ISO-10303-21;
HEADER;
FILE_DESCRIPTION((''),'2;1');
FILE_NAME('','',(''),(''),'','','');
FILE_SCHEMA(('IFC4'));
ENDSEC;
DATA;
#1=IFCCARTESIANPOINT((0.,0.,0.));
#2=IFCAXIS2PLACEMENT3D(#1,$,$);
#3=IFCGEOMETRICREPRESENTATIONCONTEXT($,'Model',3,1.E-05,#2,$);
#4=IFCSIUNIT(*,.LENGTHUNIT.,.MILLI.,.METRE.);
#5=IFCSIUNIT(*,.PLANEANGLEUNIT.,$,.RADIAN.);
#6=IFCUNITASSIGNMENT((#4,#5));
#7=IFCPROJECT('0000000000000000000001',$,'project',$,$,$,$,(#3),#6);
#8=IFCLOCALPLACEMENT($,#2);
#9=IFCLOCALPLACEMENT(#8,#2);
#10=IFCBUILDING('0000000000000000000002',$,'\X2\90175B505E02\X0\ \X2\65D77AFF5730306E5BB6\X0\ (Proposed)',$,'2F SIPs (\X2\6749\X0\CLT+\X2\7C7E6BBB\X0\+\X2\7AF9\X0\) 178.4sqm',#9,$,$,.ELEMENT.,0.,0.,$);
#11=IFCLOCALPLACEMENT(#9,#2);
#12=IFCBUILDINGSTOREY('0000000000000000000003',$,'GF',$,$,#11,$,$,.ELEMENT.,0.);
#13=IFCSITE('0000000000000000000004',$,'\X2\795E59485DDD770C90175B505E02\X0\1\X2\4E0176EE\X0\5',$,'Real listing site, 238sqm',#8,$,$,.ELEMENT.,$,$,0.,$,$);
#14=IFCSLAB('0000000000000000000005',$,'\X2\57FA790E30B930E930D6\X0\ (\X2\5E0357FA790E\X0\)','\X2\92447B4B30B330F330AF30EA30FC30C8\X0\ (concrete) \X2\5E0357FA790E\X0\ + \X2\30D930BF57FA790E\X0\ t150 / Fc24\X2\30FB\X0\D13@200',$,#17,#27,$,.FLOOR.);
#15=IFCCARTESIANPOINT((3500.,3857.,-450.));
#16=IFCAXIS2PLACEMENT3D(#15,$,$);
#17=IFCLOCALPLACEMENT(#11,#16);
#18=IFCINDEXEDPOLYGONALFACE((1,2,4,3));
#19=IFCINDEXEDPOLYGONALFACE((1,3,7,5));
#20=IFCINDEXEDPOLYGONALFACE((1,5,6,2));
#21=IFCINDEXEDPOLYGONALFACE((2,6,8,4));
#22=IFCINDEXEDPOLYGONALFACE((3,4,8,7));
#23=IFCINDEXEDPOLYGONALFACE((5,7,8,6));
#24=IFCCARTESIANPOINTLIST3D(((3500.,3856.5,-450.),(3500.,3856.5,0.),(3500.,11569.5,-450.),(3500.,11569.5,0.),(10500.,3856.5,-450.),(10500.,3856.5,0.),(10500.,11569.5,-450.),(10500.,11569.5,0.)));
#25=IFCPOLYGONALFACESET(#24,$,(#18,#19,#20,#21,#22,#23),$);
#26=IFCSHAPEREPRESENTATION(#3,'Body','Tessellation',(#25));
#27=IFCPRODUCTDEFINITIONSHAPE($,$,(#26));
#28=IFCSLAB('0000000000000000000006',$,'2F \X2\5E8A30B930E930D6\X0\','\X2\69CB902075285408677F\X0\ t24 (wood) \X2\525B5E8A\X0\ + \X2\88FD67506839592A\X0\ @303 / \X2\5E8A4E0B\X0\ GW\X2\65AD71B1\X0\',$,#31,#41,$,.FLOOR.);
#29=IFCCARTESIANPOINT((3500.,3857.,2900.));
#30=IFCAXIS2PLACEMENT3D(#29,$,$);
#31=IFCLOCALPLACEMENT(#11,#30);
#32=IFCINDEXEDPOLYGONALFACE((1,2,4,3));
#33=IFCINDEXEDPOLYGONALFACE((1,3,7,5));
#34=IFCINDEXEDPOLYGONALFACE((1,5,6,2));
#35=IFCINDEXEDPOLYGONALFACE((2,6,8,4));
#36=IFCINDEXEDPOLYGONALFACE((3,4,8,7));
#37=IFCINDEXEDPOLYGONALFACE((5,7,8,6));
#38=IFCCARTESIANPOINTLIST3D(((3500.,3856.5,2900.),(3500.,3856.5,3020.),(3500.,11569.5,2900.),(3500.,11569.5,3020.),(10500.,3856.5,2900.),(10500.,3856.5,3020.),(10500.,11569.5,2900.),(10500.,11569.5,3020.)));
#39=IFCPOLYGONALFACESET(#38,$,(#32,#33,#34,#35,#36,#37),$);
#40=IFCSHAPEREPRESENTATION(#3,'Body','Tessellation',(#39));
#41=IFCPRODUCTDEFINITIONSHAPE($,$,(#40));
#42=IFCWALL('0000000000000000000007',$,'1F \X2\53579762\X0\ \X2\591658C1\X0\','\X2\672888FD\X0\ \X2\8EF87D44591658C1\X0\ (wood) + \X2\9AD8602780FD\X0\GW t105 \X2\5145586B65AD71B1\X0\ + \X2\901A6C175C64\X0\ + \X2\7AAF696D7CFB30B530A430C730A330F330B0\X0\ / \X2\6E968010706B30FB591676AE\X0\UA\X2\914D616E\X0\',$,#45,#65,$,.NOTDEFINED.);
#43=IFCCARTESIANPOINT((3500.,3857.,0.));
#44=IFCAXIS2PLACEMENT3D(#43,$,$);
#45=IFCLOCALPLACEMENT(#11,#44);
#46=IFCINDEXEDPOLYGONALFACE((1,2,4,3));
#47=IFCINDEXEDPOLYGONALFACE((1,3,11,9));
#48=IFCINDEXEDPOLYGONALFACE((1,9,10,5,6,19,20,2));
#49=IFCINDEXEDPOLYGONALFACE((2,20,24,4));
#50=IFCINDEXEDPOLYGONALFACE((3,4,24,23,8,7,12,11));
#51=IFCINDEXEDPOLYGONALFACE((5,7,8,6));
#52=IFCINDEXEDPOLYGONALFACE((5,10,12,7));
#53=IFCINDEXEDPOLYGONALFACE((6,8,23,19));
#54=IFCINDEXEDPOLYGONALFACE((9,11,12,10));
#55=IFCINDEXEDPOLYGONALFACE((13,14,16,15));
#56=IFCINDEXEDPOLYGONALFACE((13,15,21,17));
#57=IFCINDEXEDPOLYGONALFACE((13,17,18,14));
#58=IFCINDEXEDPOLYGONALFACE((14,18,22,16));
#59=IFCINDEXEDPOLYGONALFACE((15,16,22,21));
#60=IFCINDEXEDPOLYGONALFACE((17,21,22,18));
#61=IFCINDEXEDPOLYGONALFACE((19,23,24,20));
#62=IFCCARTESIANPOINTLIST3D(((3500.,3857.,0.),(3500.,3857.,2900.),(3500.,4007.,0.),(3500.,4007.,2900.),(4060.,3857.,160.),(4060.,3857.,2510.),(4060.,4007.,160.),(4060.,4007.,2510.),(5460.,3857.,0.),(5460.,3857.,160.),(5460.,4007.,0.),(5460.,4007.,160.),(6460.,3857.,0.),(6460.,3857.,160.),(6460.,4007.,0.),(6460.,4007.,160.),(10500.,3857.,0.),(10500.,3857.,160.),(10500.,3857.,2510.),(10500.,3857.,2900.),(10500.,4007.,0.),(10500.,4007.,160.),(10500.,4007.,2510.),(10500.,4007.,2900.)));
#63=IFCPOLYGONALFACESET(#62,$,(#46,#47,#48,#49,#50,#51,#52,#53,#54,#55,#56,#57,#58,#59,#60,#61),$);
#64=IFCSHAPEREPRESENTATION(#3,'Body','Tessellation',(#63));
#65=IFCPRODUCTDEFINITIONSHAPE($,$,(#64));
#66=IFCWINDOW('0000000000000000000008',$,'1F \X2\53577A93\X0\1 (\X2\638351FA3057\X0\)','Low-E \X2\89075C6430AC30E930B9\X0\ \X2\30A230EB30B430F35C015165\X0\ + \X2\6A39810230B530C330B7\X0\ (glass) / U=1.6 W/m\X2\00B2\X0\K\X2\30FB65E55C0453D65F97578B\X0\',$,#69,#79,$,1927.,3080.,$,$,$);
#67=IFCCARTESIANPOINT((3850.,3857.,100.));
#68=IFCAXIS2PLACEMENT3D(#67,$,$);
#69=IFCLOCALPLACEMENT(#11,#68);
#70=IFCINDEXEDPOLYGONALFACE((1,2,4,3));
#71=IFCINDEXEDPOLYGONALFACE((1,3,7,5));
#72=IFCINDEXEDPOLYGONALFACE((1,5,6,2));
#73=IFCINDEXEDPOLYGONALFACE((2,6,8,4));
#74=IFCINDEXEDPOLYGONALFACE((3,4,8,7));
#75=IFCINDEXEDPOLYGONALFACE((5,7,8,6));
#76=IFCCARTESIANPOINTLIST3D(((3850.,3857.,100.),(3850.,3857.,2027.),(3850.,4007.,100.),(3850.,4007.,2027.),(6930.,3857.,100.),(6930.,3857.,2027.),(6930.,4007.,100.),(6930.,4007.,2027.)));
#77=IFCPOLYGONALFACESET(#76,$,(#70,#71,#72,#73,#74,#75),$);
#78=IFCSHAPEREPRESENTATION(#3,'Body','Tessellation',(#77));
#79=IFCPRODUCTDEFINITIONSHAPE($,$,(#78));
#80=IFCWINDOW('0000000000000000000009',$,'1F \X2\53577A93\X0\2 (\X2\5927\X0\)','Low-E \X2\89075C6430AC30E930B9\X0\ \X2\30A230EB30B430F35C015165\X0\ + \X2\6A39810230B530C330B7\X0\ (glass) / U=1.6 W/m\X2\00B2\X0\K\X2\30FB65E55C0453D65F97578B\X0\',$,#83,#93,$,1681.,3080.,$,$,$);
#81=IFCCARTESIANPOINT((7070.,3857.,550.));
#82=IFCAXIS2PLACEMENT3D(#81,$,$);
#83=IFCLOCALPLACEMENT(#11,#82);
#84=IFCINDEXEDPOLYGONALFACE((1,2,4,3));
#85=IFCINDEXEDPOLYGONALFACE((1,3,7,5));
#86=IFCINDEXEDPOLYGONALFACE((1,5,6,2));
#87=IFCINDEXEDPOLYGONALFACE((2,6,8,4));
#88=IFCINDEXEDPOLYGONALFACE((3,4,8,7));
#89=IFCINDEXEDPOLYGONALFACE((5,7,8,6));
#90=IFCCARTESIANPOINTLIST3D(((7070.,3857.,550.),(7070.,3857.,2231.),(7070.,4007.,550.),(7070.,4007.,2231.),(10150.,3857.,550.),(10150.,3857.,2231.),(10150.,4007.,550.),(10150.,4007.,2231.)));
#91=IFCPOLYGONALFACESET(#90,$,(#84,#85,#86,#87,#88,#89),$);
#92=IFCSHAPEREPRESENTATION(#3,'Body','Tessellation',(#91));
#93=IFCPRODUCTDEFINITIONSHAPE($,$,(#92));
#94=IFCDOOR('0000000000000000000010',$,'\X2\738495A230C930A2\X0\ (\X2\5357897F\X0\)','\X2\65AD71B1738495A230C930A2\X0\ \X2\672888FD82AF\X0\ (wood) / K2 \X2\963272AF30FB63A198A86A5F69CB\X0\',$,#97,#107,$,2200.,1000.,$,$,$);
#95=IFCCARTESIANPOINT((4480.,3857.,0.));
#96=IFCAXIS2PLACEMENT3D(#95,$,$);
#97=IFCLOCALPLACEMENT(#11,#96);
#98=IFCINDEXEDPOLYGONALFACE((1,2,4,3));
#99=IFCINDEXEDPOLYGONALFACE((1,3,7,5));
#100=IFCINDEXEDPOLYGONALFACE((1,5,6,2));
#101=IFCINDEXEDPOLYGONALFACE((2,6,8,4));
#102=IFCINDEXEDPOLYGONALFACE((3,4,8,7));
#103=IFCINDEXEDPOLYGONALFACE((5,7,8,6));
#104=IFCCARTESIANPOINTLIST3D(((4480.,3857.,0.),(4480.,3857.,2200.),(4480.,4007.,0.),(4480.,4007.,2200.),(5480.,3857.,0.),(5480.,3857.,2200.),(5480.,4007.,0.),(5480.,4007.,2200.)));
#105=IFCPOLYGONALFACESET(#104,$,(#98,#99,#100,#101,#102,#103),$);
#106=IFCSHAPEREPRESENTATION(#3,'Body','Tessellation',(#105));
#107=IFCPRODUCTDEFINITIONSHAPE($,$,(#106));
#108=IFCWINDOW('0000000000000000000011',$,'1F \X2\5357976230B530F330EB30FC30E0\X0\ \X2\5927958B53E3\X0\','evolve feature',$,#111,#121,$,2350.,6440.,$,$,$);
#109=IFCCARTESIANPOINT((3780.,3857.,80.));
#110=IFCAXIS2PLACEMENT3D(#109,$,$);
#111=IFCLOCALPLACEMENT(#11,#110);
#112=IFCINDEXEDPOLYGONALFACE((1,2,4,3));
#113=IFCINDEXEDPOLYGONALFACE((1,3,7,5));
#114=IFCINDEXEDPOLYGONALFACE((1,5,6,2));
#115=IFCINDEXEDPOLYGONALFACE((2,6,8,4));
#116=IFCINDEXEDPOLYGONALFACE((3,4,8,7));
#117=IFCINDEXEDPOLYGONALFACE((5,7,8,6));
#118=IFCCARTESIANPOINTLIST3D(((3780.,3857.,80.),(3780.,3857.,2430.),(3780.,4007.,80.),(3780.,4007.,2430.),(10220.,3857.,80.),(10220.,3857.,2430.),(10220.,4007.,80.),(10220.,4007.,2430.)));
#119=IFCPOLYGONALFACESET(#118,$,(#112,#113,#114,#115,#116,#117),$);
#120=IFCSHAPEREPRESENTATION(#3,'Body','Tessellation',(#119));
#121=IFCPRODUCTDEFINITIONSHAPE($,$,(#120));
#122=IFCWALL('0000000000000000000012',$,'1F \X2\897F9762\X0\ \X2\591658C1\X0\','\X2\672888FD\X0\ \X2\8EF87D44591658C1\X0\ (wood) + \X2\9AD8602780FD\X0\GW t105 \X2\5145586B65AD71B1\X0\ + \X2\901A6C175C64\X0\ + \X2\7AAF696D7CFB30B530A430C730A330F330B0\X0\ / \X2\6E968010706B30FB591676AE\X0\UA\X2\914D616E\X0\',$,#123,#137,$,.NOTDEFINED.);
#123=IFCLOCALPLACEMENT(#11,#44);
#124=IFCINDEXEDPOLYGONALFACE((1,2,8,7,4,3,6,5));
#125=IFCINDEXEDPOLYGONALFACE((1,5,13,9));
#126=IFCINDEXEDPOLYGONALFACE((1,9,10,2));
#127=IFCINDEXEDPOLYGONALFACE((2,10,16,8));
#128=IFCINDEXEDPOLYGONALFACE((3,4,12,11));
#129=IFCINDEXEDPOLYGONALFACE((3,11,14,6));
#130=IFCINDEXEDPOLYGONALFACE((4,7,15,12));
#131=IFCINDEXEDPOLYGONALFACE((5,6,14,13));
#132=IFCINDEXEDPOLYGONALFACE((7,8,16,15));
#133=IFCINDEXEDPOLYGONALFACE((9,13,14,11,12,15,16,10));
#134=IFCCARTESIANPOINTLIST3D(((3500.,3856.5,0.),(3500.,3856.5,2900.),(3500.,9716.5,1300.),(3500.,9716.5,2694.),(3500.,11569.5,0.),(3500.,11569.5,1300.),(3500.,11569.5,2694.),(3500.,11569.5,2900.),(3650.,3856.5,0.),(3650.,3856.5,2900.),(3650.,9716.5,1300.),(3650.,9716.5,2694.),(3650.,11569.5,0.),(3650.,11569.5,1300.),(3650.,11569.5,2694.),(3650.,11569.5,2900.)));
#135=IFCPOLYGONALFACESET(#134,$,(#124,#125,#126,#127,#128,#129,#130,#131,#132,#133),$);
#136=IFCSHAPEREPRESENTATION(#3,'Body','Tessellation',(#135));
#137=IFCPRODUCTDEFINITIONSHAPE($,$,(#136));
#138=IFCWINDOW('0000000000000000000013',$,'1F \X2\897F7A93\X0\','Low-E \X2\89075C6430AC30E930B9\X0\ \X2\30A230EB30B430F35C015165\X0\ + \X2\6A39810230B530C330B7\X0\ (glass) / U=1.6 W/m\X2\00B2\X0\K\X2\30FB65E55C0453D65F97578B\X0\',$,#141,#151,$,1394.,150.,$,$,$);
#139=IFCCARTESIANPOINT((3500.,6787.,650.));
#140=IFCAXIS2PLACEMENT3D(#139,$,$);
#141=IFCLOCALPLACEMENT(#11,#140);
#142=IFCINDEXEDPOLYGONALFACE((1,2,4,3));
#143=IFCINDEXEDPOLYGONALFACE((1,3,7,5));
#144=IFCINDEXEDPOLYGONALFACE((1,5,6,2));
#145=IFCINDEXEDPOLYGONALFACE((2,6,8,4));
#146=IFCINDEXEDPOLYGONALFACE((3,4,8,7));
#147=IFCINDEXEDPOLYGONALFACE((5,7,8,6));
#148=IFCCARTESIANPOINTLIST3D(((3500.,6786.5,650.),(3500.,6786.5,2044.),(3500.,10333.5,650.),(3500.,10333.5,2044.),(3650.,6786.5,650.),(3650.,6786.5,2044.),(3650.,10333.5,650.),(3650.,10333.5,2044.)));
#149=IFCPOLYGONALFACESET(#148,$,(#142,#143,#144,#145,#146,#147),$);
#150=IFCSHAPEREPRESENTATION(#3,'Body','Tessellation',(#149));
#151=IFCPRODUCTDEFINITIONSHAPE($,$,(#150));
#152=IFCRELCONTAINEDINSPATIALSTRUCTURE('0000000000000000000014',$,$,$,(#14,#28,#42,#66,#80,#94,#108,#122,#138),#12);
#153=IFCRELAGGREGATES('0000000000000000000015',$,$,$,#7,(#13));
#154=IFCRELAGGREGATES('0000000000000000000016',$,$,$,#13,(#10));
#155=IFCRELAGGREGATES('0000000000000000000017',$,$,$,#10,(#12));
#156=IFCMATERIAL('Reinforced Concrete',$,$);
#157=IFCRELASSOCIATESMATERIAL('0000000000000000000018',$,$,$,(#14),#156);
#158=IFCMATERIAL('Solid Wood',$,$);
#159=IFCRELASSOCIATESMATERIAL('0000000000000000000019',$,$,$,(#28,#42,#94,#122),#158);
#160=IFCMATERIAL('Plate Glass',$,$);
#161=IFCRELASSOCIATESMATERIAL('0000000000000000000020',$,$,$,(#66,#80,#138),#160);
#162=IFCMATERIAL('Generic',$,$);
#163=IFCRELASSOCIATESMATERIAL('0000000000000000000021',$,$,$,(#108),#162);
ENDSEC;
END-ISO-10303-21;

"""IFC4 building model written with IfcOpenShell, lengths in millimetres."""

from ifc_helpers import new_model, si_unit, frame, frame_2d, origin, place, context, project, spatial, rectangle, extrude, material, element, fill, save


model = new_model("IFC4")

# Units and contexts
model_context = context("Model", 3, precision=1e-05, world=origin())
ifc_project = project(units=[si_unit("LENGTHUNIT", "METRE", prefix="MILLI"), si_unit("PLANEANGLEUNIT", "RADIAN")], contexts=[model_context])

# Site, building, storey
site_placement = place(None, origin())
site = spatial("IfcSite", under=ifc_project, at=site_placement, Name="神奈川県逗子市1丁目5", ObjectType="Real listing site, 238sqm", CompositionType="ELEMENT", RefElevation=0.0)
building_placement = place(site_placement, origin())
building = spatial("IfcBuilding", under=site, at=building_placement, Name="逗子市 旗竿地の家 (Proposed)", ObjectType="2F SIPs (杉CLT+籾殻+竹) 178.4sqm", CompositionType="ELEMENT", ElevationOfRefHeight=0.0, ElevationOfTerrain=0.0)
storey_placement = place(building_placement, origin())
storey = spatial("IfcBuildingStorey", under=building, at=storey_placement, Name="GF", CompositionType="ELEMENT", Elevation=0.0)

# Slabs
ifc_material_1 = material(Name="Reinforced Concrete")
slab_1_placement = place(storey_placement, frame((3500.0, 3857.0, -450.0)))
element("IfcSlab", 1, at=slab_1_placement, inside=storey, material=ifc_material_1, Name="基礎スラブ (布基礎)", Description="鉄筋コンクリート (concrete) 布基礎 + ベタ基礎 t150 / Fc24・D13@200", PredefinedType="FLOOR", context=model_context, shape_type="SweptSolid", body=[
    extrude(rectangle(XDim=7000.0, YDim=7713.0, at=frame_2d((3500.0, 3856.0))), frame((3500.0, 3857.0, -450.0)), (0.0, 0.0, 1.0), 450.0),
])
ifc_material_2 = material(Name="Solid Wood")
slab_2_placement = place(storey_placement, frame((3500.0, 3857.0, 2900.0)))
element("IfcSlab", 2, at=slab_2_placement, inside=storey, material=ifc_material_2, Name="2F 床スラブ", Description="構造用合板 t24 (wood) 剛床 + 製材根太 @303 / 床下 GW断熱", PredefinedType="FLOOR", context=model_context, shape_type="SweptSolid", body=[
    extrude(rectangle(XDim=7000.0, YDim=7713.0, at=frame_2d((3500.0, 3856.0))), frame((3500.0, 3857.0, 2900.0)), (0.0, 0.0, 1.0), 120.0),
])
ifc_material_3 = material(Name="Generic")

# Wall, openings, windows, door
wall_1_placement = place(storey_placement, frame((3500.0, 3857.0, 0.0)))
wall_1 = element("IfcWall", 3, at=wall_1_placement, inside=storey, material=ifc_material_2, Name="1F 南面 外壁", Description="木製 軸組外壁 (wood) + 高性能GW t105 充填断熱 + 通気層 + 窯業系サイディング / 準耐火・外皮UA配慮", PredefinedType="NOTDEFINED", context=model_context, shape_type="SweptSolid", body=[
    extrude(rectangle(XDim=7000.0, YDim=150.0, at=frame_2d((3500.0, 75.0))), frame((3500.0, 3857.0, 0.0)), (0.0, 0.0, 1.0), 2900.0),
])
opening_1_placement = place(storey_placement, frame((3850.0, 3857.0, 100.0)))
opening_1 = element("IfcOpeningElement", 4, at=opening_1_placement, cuts=wall_1, PredefinedType="NOTDEFINED", context=model_context, shape_type="SweptSolid", body=[
    extrude(rectangle(XDim=3080.0, YDim=150.0, at=frame_2d((1540.0, 75.0))), frame((3850.0, 3857.0, 100.0)), (0.0, 0.0, 1.0), 1927.0),
])
opening_2_placement = place(storey_placement, frame((7070.0, 3857.0, 550.0)))
opening_2 = element("IfcOpeningElement", 5, at=opening_2_placement, cuts=wall_1, PredefinedType="NOTDEFINED", context=model_context, shape_type="SweptSolid", body=[
    extrude(rectangle(XDim=3080.0, YDim=150.0, at=frame_2d((1540.0, 75.0))), frame((7070.0, 3857.0, 550.0)), (0.0, 0.0, 1.0), 1681.0),
])
opening_3_placement = place(storey_placement, frame((4480.0, 3857.0, 0.0)))
opening_3 = element("IfcOpeningElement", 6, at=opening_3_placement, cuts=wall_1, PredefinedType="NOTDEFINED", context=model_context, shape_type="SweptSolid", body=[
    extrude(rectangle(XDim=1000.0, YDim=150.0, at=frame_2d((500.0, 75.0))), frame((4480.0, 3857.0, 0.0)), (0.0, 0.0, 1.0), 2200.0),
])
opening_4_placement = place(storey_placement, frame((3780.0, 3857.0, 80.0)))
opening_4 = element("IfcOpeningElement", 7, at=opening_4_placement, cuts=wall_1, PredefinedType="NOTDEFINED", context=model_context, shape_type="SweptSolid", body=[
    extrude(rectangle(XDim=6440.0, YDim=150.0, at=frame_2d((3220.0, 75.0))), frame((3780.0, 3857.0, 80.0)), (0.0, 0.0, 1.0), 2350.0),
])
ifc_material_4 = material(Name="Plate Glass")
window_1_placement = place(storey_placement, frame((3850.0, 3857.0, 100.0)))
window_1 = element("IfcWindow", 8, at=window_1_placement, inside=storey, material=ifc_material_4, Name="1F 南窓1 (掃出し)", Description="Low-E 複層ガラス アルゴン封入 + 樹脂サッシ (glass) / U=1.6 W/m²K・日射取得型", OverallHeight=1927.0, OverallWidth=3080.0, context=model_context, shape_type="SweptSolid", body=[
    extrude(rectangle(XDim=3080.0, YDim=150.0, at=frame_2d((1540.0, 75.0))), frame((3850.0, 3857.0, 100.0)), (0.0, 0.0, 1.0), 1927.0),
])
fill(opening_1, window_1)
window_2_placement = place(storey_placement, frame((7070.0, 3857.0, 550.0)))
window_2 = element("IfcWindow", 9, at=window_2_placement, inside=storey, material=ifc_material_4, Name="1F 南窓2 (大)", Description="Low-E 複層ガラス アルゴン封入 + 樹脂サッシ (glass) / U=1.6 W/m²K・日射取得型", OverallHeight=1681.0, OverallWidth=3080.0, context=model_context, shape_type="SweptSolid", body=[
    extrude(rectangle(XDim=3080.0, YDim=150.0, at=frame_2d((1540.0, 75.0))), frame((7070.0, 3857.0, 550.0)), (0.0, 0.0, 1.0), 1681.0),
])
fill(opening_2, window_2)
door_placement = place(storey_placement, frame((4480.0, 3857.0, 0.0)))
door = element("IfcDoor", 10, at=door_placement, inside=storey, material=ifc_material_2, Name="玄関ドア (南西)", Description="断熱玄関ドア 木製芯 (wood) / K2 防犯・採風機構", OverallHeight=2200.0, OverallWidth=1000.0, context=model_context, shape_type="SweptSolid", body=[
    extrude(rectangle(XDim=1000.0, YDim=150.0, at=frame_2d((500.0, 75.0))), frame((4480.0, 3857.0, 0.0)), (0.0, 0.0, 1.0), 2200.0),
])
fill(opening_3, door)
window_3_placement = place(storey_placement, frame((3780.0, 3857.0, 80.0)))
window_3 = element("IfcWindow", 11, at=window_3_placement, inside=storey, material=ifc_material_3, Name="1F 南面サンルーム 大開口", Description="evolve feature", OverallHeight=2350.0, OverallWidth=6440.0, context=model_context, shape_type="SweptSolid", body=[
    extrude(rectangle(XDim=6440.0, YDim=150.0, at=frame_2d((3220.0, 75.0))), frame((3780.0, 3857.0, 80.0)), (0.0, 0.0, 1.0), 2350.0),
])
fill(opening_4, window_3)

# Wall, opening, window
wall_2_placement = place(storey_placement, frame((3500.0, 3857.0, 0.0)))
wall_2 = element("IfcWall", 12, at=wall_2_placement, inside=storey, material=ifc_material_2, Name="1F 西面 外壁", Description="木製 軸組外壁 (wood) + 高性能GW t105 充填断熱 + 通気層 + 窯業系サイディング / 準耐火・外皮UA配慮", PredefinedType="NOTDEFINED", context=model_context, shape_type="SweptSolid", body=[
    extrude(rectangle(XDim=150.0, YDim=7713.0, at=frame_2d((75.0, 3856.0))), frame((3500.0, 3857.0, 0.0)), (0.0, 0.0, 1.0), 2900.0),
])
opening_5_placement = place(storey_placement, frame((3500.0, 6787.0, 650.0)))
opening_5 = element("IfcOpeningElement", 13, at=opening_5_placement, cuts=wall_2, PredefinedType="NOTDEFINED", context=model_context, shape_type="SweptSolid", body=[
    extrude(rectangle(XDim=150.0, YDim=3547.0, at=frame_2d((75.0, 1773.0))), frame((3500.0, 6787.0, 650.0)), (0.0, 0.0, 1.0), 1394.0),
])
window_4_placement = place(storey_placement, frame((3500.0, 6787.0, 650.0)))
window_4 = element("IfcWindow", 14, at=window_4_placement, inside=storey, material=ifc_material_4, Name="1F 西窓", Description="Low-E 複層ガラス アルゴン封入 + 樹脂サッシ (glass) / U=1.6 W/m²K・日射取得型", OverallHeight=1394.0, OverallWidth=150.0, context=model_context, shape_type="SweptSolid", body=[
    extrude(rectangle(XDim=150.0, YDim=3547.0, at=frame_2d((75.0, 1773.0))), frame((3500.0, 6787.0, 650.0)), (0.0, 0.0, 1.0), 1394.0),
])
fill(opening_5, window_4)

save(model, "model.ifc")
